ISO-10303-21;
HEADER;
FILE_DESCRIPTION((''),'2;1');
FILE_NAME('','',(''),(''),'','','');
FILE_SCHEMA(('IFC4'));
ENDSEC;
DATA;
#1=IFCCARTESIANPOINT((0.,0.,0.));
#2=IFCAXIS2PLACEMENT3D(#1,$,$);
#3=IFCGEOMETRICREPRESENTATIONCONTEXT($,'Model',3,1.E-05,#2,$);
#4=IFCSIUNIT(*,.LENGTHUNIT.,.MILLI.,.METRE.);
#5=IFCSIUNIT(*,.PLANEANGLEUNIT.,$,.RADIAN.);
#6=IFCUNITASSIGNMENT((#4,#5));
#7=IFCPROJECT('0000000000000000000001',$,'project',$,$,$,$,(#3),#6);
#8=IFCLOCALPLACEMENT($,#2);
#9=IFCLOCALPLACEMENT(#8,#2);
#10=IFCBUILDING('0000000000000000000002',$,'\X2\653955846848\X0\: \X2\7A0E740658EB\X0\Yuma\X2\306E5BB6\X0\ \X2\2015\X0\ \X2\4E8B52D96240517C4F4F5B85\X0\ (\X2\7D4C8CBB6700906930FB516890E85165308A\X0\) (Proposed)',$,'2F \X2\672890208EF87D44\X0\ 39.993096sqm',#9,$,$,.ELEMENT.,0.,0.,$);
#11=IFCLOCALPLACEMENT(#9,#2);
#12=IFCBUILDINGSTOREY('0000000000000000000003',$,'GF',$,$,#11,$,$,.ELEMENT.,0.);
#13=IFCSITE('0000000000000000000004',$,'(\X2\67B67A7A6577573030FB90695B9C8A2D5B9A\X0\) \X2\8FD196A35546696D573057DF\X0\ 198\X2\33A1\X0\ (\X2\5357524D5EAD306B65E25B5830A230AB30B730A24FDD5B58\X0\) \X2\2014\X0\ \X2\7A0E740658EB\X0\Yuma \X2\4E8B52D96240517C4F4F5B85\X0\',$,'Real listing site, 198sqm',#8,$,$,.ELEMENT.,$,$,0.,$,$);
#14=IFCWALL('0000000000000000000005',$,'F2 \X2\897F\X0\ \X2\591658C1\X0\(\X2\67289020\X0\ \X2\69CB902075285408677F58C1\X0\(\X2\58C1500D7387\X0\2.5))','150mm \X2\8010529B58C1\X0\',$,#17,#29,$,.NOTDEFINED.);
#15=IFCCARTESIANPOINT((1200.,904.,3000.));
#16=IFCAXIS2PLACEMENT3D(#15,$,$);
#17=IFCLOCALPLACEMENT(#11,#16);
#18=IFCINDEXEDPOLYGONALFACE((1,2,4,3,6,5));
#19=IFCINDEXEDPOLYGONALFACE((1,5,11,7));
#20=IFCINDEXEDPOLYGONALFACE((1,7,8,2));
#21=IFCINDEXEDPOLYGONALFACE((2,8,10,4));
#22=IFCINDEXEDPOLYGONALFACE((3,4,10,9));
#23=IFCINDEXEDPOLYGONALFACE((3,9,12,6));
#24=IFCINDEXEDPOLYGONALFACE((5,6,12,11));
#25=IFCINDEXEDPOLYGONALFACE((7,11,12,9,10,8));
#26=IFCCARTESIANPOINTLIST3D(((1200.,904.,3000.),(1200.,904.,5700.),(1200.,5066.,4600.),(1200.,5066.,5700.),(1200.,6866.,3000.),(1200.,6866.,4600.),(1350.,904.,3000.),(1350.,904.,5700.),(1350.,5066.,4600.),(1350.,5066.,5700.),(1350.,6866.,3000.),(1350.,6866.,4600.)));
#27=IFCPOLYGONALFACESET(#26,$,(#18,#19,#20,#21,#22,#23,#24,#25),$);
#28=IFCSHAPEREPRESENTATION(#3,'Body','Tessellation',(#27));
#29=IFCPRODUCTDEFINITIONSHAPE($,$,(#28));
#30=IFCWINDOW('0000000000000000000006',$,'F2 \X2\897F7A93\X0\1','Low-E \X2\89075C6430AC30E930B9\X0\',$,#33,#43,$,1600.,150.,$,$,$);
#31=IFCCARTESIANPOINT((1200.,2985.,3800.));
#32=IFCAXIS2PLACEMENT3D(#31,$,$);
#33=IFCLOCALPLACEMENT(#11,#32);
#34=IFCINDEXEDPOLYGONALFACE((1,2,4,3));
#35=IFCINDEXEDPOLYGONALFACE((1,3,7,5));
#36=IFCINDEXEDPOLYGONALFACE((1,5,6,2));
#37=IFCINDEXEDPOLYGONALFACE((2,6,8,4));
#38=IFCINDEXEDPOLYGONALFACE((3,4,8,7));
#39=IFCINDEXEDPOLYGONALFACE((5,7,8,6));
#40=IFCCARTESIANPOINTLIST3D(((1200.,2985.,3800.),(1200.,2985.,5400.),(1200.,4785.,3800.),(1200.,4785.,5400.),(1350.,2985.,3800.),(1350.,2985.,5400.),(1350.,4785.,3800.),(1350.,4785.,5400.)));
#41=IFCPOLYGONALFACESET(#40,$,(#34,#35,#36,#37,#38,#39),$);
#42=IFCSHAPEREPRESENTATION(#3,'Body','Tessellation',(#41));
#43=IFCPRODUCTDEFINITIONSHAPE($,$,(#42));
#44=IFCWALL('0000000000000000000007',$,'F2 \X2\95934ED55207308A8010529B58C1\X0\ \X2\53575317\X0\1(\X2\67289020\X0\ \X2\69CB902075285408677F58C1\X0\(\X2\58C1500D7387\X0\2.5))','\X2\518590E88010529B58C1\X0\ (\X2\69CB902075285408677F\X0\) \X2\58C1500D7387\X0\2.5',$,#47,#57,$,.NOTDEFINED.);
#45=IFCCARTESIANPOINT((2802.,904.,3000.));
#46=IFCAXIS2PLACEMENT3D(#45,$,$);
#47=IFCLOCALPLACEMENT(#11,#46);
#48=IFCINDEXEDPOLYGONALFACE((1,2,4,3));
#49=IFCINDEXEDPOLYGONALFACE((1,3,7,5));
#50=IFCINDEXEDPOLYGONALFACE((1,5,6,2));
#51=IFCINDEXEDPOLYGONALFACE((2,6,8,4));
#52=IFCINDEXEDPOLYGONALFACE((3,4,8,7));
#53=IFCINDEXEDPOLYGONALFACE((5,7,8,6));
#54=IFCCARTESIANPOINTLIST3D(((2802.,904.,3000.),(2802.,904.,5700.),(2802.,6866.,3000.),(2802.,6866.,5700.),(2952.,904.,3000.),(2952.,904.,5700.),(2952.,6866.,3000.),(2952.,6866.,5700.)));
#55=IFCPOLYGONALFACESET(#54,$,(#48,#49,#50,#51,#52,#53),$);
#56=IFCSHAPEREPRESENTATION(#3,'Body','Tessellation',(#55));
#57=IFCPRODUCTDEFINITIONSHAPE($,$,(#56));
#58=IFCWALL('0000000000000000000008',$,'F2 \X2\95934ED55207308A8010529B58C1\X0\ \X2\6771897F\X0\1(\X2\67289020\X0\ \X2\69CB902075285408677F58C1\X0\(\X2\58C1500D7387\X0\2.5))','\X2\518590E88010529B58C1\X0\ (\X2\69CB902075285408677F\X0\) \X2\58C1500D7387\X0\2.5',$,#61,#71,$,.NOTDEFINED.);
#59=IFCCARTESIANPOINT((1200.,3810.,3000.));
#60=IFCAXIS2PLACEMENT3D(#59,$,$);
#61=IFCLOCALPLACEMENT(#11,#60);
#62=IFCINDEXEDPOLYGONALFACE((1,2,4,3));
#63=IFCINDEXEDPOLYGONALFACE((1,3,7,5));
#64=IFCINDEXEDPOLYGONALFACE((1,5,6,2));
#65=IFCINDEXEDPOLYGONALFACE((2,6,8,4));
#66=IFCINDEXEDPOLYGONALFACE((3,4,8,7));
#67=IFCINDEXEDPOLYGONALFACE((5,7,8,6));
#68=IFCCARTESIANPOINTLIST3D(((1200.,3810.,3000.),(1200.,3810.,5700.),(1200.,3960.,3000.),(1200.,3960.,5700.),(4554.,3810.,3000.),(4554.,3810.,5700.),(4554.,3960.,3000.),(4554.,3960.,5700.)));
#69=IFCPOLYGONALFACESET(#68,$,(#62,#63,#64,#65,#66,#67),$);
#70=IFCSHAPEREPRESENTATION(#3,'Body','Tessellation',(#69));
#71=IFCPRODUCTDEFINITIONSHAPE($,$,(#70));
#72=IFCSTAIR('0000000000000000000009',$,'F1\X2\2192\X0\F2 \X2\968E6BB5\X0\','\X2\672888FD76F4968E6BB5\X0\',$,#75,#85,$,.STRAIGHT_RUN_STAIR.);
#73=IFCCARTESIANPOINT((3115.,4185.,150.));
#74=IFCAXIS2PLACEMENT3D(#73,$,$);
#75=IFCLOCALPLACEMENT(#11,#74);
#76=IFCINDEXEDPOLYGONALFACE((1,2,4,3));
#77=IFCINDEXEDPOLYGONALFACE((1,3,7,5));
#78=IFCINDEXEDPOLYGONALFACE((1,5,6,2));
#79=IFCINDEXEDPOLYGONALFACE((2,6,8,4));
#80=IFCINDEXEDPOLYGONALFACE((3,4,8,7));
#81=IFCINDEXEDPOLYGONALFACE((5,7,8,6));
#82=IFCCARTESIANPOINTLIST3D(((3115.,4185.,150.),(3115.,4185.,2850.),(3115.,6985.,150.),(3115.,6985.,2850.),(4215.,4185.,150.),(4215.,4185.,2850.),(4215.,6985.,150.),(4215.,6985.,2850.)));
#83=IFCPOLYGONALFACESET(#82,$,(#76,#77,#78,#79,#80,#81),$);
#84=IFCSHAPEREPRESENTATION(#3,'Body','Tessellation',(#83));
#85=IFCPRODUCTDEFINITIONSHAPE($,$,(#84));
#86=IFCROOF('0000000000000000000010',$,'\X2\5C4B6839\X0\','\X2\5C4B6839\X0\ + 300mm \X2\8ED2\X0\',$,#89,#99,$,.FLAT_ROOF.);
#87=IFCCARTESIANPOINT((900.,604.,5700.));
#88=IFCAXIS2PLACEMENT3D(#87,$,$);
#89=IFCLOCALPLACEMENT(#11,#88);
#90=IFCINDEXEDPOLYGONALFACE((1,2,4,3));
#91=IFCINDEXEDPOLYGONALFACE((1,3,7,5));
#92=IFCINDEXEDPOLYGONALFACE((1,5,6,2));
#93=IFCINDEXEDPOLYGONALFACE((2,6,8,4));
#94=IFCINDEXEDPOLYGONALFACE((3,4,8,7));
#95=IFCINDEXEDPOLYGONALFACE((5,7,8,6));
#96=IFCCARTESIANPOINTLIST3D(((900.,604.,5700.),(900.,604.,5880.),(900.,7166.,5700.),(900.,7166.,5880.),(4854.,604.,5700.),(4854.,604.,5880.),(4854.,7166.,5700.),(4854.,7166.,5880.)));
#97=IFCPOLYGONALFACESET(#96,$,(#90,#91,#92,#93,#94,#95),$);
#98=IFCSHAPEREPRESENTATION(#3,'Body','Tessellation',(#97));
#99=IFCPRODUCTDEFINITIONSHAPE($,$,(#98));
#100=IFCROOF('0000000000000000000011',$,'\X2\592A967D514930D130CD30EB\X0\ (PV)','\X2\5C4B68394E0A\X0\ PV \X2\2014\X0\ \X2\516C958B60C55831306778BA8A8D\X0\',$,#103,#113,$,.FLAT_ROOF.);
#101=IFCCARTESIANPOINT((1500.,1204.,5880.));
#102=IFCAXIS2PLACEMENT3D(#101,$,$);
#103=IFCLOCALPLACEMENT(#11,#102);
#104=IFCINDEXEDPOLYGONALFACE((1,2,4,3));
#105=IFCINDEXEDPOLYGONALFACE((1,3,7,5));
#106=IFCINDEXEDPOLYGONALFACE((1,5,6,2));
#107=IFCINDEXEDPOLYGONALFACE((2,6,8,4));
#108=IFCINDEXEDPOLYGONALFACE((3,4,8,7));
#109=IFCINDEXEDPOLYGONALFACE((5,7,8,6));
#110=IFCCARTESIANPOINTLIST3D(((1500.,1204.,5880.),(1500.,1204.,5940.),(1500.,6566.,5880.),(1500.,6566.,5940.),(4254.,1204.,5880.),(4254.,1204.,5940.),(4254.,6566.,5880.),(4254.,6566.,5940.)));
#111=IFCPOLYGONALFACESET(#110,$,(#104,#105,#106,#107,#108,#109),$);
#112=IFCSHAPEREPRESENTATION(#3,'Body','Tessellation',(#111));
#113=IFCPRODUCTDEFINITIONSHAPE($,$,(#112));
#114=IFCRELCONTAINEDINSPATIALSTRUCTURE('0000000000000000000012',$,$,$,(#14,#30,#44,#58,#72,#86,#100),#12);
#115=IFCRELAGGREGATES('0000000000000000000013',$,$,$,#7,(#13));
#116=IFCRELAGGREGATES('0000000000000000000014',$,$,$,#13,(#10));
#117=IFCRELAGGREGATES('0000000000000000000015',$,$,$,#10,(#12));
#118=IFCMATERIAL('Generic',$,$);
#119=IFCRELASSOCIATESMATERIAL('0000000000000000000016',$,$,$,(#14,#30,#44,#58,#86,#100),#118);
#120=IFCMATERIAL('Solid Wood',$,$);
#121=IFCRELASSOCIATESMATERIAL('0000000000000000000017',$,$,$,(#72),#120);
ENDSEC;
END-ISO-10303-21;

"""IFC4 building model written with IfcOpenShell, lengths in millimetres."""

from ifc_helpers import new_model, si_unit, frame, frame_2d, origin, place, context, project, spatial, rectangle, extrude, material, element, fill, save


model = new_model("IFC4")

# Units and contexts
model_context = context("Model", 3, precision=1e-05, world=origin())
ifc_project = project(units=[si_unit("LENGTHUNIT", "METRE", prefix="MILLI"), si_unit("PLANEANGLEUNIT", "RADIAN")], contexts=[model_context])

# Site, building, storey
site_placement = place(None, origin())
site = spatial("IfcSite", under=ifc_project, at=site_placement, Name="(架空敷地・適宜設定) 近隣商業地域 198㎡ (南前庭に既存アカシア保存) — 税理士Yuma 事務所兼住宅", ObjectType="Real listing site, 198sqm", CompositionType="ELEMENT", RefElevation=0.0)
building_placement = place(site_placement, origin())
building = spatial("IfcBuilding", under=site, at=building_placement, Name="改善案: 税理士Yumaの家 ― 事務所兼住宅 (経費最適・全部入り) (Proposed)", ObjectType="2F 木造軸組 39.993096sqm", CompositionType="ELEMENT", ElevationOfRefHeight=0.0, ElevationOfTerrain=0.0)
storey_placement = place(building_placement, origin())
storey = spatial("IfcBuildingStorey", under=building, at=storey_placement, Name="GF", CompositionType="ELEMENT", Elevation=0.0)

# Shared definitions
ifc_material_1 = material(Name="Generic")

# Shared definitions
ifc_material_2 = material(Name="Solid Wood")

# Wall, opening, window
wall_1_placement = place(storey_placement, frame((1200.0, 904.0, 3000.0)))
wall_1 = element("IfcWall", 1, at=wall_1_placement, inside=storey, material=ifc_material_1, Name="F2 西 外壁(木造 構造用合板壁(壁倍率2.5))", Description="150mm 耐力壁", PredefinedType="NOTDEFINED", context=model_context, shape_type="SweptSolid", body=[
    extrude(rectangle(XDim=150.0, YDim=5962.0, at=frame_2d((75.0, 2981.0))), frame((1200.0, 904.0, 3000.0)), (0.0, 0.0, 1.0), 2700.0),
])
opening_1_placement = place(storey_placement, frame((1200.0, 2985.0, 3800.0)))
opening_1 = element("IfcOpeningElement", 2, at=opening_1_placement, cuts=wall_1, PredefinedType="NOTDEFINED", context=model_context, shape_type="SweptSolid", body=[
    extrude(rectangle(XDim=150.0, YDim=1800.0, at=frame_2d((75.0, 900.0))), frame((1200.0, 2985.0, 3800.0)), (0.0, 0.0, 1.0), 1600.0),
])
window_1_placement = place(storey_placement, frame((1200.0, 2985.0, 3800.0)))
window_1 = element("IfcWindow", 3, at=window_1_placement, inside=storey, material=ifc_material_1, Name="F2 西窓1", Description="Low-E 複層ガラス", OverallHeight=1600.0, OverallWidth=150.0, context=model_context, shape_type="SweptSolid", body=[
    extrude(rectangle(XDim=150.0, YDim=1800.0, at=frame_2d((75.0, 900.0))), frame((1200.0, 2985.0, 3800.0)), (0.0, 0.0, 1.0), 1600.0),
])
fill(opening_1, window_1)

# Walls
wall_2_placement = place(storey_placement, frame((2802.0, 904.0, 3000.0)))
element("IfcWall", 4, at=wall_2_placement, inside=storey, material=ifc_material_1, Name="F2 間仕切り耐力壁 南北1(木造 構造用合板壁(壁倍率2.5))", Description="内部耐力壁 (構造用合板) 壁倍率2.5", PredefinedType="NOTDEFINED", context=model_context, shape_type="SweptSolid", body=[
    extrude(rectangle(XDim=150.0, YDim=5962.0, at=frame_2d((75.0, 2981.0))), frame((2802.0, 904.0, 3000.0)), (0.0, 0.0, 1.0), 2700.0),
])
wall_3_placement = place(storey_placement, frame((1200.0, 3810.0, 3000.0)))
element("IfcWall", 5, at=wall_3_placement, inside=storey, material=ifc_material_1, Name="F2 間仕切り耐力壁 東西1(木造 構造用合板壁(壁倍率2.5))", Description="内部耐力壁 (構造用合板) 壁倍率2.5", PredefinedType="NOTDEFINED", context=model_context, shape_type="SweptSolid", body=[
    extrude(rectangle(XDim=3354.0, YDim=150.0, at=frame_2d((1677.0, 75.0))), frame((1200.0, 3810.0, 3000.0)), (0.0, 0.0, 1.0), 2700.0),
])

# Stair
stair_placement = place(storey_placement, frame((3115.0, 4185.0, 150.0)))
element("IfcStair", 6, at=stair_placement, inside=storey, material=ifc_material_2, Name="F1→F2 階段", Description="木製直階段", PredefinedType="STRAIGHT_RUN_STAIR", context=model_context, shape_type="SweptSolid", body=[
    extrude(rectangle(XDim=1100.0, YDim=2800.0, at=frame_2d((550.0, 1400.0))), frame((3115.0, 4185.0, 150.0)), (0.0, 0.0, 1.0), 2700.0),
])

# Roofs
roof_1_placement = place(storey_placement, frame((900.0, 604.0, 5700.0)))
element("IfcRoof", 7, at=roof_1_placement, inside=storey, material=ifc_material_1, Name="屋根", Description="屋根 + 300mm 軒", PredefinedType="FLAT_ROOF", context=model_context, shape_type="SweptSolid", body=[
    extrude(rectangle(XDim=3954.0, YDim=6562.0, at=frame_2d((1977.0, 3281.0))), frame((900.0, 604.0, 5700.0)), (0.0, 0.0, 1.0), 180.0),
])
roof_2_placement = place(storey_placement, frame((1500.0, 1204.0, 5880.0)))
element("IfcRoof", 8, at=roof_2_placement, inside=storey, material=ifc_material_1, Name="太陽光パネル (PV)", Description="屋根上 PV — 公開情報で確認", PredefinedType="FLAT_ROOF", context=model_context, shape_type="SweptSolid", body=[
    extrude(rectangle(XDim=2754.0, YDim=5362.0, at=frame_2d((1377.0, 2681.0))), frame((1500.0, 1204.0, 5880.0)), (0.0, 0.0, 1.0), 60.0),
])

save(model, "model.ifc")
